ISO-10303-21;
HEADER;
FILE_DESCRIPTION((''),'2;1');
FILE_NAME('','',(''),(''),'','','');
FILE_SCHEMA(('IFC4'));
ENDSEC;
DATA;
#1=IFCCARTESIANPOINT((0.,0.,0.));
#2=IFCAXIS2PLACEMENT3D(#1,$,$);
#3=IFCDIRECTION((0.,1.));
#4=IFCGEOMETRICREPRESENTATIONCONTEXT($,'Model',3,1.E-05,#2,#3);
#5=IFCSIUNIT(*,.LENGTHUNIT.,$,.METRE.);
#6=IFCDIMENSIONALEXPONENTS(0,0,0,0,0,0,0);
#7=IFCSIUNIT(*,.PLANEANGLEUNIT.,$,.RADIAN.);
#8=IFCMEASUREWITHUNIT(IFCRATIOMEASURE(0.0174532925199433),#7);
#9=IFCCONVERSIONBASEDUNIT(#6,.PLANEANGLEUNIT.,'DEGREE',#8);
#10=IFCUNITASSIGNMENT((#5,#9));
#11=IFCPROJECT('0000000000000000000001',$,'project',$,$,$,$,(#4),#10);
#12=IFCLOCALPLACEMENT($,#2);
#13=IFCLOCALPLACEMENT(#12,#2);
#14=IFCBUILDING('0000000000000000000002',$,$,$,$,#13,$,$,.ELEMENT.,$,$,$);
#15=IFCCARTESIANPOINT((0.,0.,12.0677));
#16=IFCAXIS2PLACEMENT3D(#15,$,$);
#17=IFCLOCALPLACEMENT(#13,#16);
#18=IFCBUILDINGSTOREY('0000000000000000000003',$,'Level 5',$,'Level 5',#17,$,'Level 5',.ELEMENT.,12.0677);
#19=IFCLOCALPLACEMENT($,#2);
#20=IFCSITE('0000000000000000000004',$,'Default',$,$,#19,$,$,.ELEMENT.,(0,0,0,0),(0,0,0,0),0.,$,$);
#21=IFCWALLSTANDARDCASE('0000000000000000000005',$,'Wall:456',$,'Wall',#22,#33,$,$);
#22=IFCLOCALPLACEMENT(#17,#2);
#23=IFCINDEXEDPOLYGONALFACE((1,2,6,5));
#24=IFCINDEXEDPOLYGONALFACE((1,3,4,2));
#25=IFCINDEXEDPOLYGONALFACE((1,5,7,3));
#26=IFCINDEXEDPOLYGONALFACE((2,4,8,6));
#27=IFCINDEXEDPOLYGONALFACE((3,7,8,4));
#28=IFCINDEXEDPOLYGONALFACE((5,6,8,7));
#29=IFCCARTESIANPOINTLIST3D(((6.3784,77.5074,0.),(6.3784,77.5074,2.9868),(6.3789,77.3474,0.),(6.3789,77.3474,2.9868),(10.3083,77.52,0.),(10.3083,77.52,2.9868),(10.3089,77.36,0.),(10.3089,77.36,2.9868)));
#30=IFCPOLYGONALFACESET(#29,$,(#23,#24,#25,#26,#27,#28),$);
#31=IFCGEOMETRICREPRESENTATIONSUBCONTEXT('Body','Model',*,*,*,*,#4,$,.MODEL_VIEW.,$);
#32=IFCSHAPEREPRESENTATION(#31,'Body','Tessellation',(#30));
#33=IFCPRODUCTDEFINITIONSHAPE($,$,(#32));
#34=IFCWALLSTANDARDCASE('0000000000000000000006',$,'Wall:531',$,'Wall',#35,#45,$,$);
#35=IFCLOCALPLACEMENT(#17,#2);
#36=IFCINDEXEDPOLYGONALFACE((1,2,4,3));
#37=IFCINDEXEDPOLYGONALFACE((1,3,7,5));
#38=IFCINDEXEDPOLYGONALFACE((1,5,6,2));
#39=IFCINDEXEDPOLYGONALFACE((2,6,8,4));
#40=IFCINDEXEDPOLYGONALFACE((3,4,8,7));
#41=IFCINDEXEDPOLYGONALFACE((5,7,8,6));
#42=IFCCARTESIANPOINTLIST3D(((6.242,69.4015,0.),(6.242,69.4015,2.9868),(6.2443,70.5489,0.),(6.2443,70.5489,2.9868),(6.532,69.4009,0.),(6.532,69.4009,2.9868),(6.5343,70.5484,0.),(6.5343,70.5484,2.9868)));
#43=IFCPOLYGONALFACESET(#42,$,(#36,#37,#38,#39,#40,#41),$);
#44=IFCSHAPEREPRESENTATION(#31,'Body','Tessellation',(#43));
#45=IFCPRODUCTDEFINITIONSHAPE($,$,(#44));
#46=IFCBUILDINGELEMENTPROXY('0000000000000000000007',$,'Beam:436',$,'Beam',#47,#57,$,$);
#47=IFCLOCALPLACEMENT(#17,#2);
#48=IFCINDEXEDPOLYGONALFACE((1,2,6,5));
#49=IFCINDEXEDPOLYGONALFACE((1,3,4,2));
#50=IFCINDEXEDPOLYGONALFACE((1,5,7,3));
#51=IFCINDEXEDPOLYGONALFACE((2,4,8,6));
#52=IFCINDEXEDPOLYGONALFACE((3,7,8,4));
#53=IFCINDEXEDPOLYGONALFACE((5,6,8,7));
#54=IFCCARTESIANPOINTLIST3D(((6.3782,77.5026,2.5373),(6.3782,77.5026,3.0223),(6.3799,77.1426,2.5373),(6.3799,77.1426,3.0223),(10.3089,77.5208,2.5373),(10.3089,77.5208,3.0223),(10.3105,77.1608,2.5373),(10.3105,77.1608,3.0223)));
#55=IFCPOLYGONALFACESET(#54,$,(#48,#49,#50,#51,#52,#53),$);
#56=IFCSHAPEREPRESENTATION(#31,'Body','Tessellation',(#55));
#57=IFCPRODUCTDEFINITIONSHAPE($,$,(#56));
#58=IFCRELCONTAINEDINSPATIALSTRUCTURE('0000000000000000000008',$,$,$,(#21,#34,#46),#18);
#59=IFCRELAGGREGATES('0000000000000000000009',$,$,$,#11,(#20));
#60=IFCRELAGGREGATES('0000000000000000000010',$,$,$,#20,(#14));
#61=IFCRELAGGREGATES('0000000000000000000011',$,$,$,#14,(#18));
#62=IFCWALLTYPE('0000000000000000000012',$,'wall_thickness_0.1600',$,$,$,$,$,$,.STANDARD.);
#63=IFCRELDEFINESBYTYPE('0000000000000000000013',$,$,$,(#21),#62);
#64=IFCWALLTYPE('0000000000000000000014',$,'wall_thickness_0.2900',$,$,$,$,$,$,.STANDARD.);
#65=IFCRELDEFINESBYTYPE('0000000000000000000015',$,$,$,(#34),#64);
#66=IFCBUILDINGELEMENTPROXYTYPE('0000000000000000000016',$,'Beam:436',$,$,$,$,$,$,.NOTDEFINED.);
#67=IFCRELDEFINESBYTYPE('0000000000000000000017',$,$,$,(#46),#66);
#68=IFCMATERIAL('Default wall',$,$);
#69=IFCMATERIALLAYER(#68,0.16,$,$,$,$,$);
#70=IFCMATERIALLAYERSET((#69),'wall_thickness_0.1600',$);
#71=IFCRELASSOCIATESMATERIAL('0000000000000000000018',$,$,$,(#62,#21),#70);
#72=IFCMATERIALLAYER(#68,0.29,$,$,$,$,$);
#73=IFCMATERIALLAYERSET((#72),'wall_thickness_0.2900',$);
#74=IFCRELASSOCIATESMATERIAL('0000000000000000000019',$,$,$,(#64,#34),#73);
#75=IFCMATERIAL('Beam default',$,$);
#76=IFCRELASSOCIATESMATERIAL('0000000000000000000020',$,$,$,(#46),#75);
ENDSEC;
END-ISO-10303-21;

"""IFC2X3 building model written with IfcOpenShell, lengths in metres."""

from ifc_helpers import new_model, entity, si_unit, converted_unit, direction, frame, origin, place, context, subcontext, project, spatial, polyline, outline, extrude, source, transform, mapped, material, layer, layer_set, layer_usage, type_object, type_shapes, element, save


model = new_model("IFC2X3")

# Units and contexts
model_context = context("Model", 3, precision=1e-05, world=origin(), true_north=direction((0.0, 1.0)))
body_context = subcontext(model_context, "Body", "Model", "MODEL_VIEW")
ifc_project = project(units=[si_unit("LENGTHUNIT", "METRE"), converted_unit("PLANEANGLEUNIT", "DEGREE", entity("IfcRatioMeasure", 0.0174532925199433), si_unit("PLANEANGLEUNIT", "RADIAN"), dimensions=[0, 0, 0, 0, 0, 0, 0])], contexts=[model_context])

# Site, building, storey
site_placement = place(None, origin())
site = spatial("IfcSite", under=ifc_project, at=site_placement, Name="Default", CompositionType="ELEMENT", RefLatitude=(0, 0, 0, 0), RefLongitude=(0, 0, 0, 0), RefElevation=0.0)
placement_1 = place(None, origin())
building_placement = place(placement_1, origin())
building = spatial("IfcBuilding", under=site, at=building_placement, CompositionType="ELEMENT")
storey_placement = place(building_placement, frame((0.0, 0.0, 12.0677)))
storey = spatial("IfcBuildingStorey", under=building, at=storey_placement, Name="Level 5", ObjectType="Level 5", LongName="Level 5", CompositionType="ELEMENT", Elevation=12.0677)

# Walls
ifc_material_1 = material(Name="Default wall")
ifc_layer_1 = layer(ifc_material_1, 0.16)
ifc_layer_set_1 = layer_set([ifc_layer_1], Name="wall_thickness_0.1600")
ifc_layer_usage_1 = layer_usage(ifc_layer_set_1, "AXIS2", "POSITIVE", -0.08)
wall_type_1 = type_object("IfcWallType", Name="wall_thickness_0.1600", PredefinedType="STANDARD", material=ifc_layer_set_1)
wall_1_placement = place(storey_placement, frame((6.3787, 77.4274, 0.0), z_axis=(0.0, 0.0, 1.0), x_axis=(0.999995, 0.003192, 0.0)))
element("IfcWallStandardCase", 1, at=wall_1_placement, inside=storey, type_object=wall_type_1, material=ifc_layer_usage_1, Name="Wall:456", ObjectType="Wall", context=body_context, shape_type="SweptSolid", body=[
    extrude(outline(polyline([(3.93, -0.08), (3.93, 0.08), (0.0, 0.08), (0.0, -0.08), (3.93, -0.08)])), origin(), (0.0, 0.0, 1.0), 2.9868),
])
ifc_layer_2 = layer(ifc_material_1, 0.29)
ifc_layer_set_2 = layer_set([ifc_layer_2], Name="wall_thickness_0.2900")
ifc_layer_usage_2 = layer_usage(ifc_layer_set_2, "AXIS2", "POSITIVE", -0.145)
wall_type_2 = type_object("IfcWallType", Name="wall_thickness_0.2900", PredefinedType="STANDARD", material=ifc_layer_set_2)
wall_2_placement = place(storey_placement, frame((6.3893, 70.5487, 0.0), z_axis=(0.0, 0.0, 1.0), x_axis=(-0.002001, -0.999998, 0.0)))
element("IfcWallStandardCase", 2, at=wall_2_placement, inside=storey, type_object=wall_type_2, material=ifc_layer_usage_2, Name="Wall:531", ObjectType="Wall", context=body_context, shape_type="SweptSolid", body=[
    extrude(outline(polyline([(1.1474, -0.145), (1.1474, 0.145), (0.0, 0.145), (0.0, -0.145), (1.1474, -0.145)])), origin(), (0.0, 0.0, 1.0), 2.9868),
])

# Building element proxy
ifc_material_2 = material(Name="Beam default")
building_element_proxy_type = type_object("IfcBuildingElementProxyType", Name="Beam:436", PredefinedType="NOTDEFINED")
shared_shape = source(origin(), body_context, "Body", "SweptSolid", [
    extrude(outline(polyline([(3.9307, -0.18), (3.9307, 0.18), (0.0, 0.18), (0.0, -0.18), (3.9307, -0.18)])), origin(), (0.0, 0.0, 1.0), 0.485),
])
type_shapes(building_element_proxy_type, [shared_shape])
placement_2 = place(building_placement, frame((0.0, 0.0, 14.605)))
proxy_placement = place(placement_2, frame((6.3791, 77.3226, 0.0), z_axis=(0.0, 0.0, 1.0), x_axis=(0.999989, 0.004641, 0.0)))
element("IfcBuildingElementProxy", 3, at=proxy_placement, inside=storey, type_object=building_element_proxy_type, material=ifc_material_2, Name="Beam:436", ObjectType="Beam", context=body_context, shape_type="MappedRepresentation", body=[
    mapped(shared_shape, transform((0.0, 0.0, 0.0), scale=1.0)),
])

save(model, "model.ifc")
